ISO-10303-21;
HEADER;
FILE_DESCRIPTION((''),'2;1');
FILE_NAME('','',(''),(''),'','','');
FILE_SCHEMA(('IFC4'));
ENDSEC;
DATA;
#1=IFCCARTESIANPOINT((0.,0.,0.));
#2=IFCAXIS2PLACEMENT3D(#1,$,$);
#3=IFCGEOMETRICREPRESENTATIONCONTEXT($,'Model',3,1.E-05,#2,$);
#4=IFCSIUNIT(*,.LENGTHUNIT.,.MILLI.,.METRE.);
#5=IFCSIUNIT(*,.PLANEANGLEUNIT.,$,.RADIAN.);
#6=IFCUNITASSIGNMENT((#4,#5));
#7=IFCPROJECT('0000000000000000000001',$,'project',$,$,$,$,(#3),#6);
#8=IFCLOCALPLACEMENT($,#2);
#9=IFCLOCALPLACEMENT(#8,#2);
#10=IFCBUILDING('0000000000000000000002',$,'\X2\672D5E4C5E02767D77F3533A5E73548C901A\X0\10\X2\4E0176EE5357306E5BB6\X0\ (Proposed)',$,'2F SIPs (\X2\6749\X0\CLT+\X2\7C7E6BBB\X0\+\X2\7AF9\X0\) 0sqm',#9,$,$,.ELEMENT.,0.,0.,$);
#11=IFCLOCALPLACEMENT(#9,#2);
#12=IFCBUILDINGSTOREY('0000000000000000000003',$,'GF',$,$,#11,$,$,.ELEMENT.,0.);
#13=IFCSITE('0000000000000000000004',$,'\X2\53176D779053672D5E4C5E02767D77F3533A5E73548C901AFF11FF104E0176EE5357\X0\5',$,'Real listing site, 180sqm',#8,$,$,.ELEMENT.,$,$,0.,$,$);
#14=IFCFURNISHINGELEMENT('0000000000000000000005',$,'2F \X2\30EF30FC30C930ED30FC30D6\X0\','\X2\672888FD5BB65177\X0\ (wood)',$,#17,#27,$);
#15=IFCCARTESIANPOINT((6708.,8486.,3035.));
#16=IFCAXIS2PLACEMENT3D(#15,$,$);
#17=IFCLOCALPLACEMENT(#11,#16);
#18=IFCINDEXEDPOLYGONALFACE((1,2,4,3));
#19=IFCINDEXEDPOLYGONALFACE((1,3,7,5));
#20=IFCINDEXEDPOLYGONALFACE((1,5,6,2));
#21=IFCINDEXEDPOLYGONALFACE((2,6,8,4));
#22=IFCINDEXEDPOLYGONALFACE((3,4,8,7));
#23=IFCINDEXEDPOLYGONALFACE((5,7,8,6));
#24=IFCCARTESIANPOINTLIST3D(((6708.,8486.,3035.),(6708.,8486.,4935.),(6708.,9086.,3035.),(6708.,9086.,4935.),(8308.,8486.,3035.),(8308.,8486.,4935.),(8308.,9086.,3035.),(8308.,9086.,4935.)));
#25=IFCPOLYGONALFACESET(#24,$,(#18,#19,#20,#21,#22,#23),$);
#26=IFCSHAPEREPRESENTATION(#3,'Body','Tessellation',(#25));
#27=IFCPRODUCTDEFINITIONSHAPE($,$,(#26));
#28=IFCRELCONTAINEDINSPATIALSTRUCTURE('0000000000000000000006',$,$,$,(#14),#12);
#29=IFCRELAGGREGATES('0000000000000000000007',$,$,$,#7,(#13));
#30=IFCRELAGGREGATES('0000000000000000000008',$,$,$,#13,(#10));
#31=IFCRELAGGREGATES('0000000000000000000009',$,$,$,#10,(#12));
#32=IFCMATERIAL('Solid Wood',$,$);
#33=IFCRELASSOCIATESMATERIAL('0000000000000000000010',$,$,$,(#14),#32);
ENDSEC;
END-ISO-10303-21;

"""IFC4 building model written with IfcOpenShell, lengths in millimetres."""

from ifc_helpers import new_model, si_unit, frame, frame_2d, origin, place, context, project, spatial, rectangle, extrude, material, element, save


model = new_model("IFC4")

# Units and contexts
model_context = context("Model", 3, precision=1e-05, world=origin())
ifc_project = project(units=[si_unit("LENGTHUNIT", "METRE", prefix="MILLI"), si_unit("PLANEANGLEUNIT", "RADIAN")], contexts=[model_context])

# Site, building, storey
site_placement = place(None, origin())
site = spatial("IfcSite", under=ifc_project, at=site_placement, Name="北海道札幌市白石区平和通１０丁目南5", ObjectType="Real listing site, 180sqm", CompositionType="ELEMENT", RefElevation=0.0)
building_placement = place(site_placement, origin())
building = spatial("IfcBuilding", under=site, at=building_placement, Name="札幌市白石区平和通10丁目南の家 (Proposed)", ObjectType="2F SIPs (杉CLT+籾殻+竹) 0sqm", CompositionType="ELEMENT", ElevationOfRefHeight=0.0, ElevationOfTerrain=0.0)
storey_placement = place(building_placement, origin())
storey = spatial("IfcBuildingStorey", under=building, at=storey_placement, Name="GF", CompositionType="ELEMENT", Elevation=0.0)

# Shared definitions
ifc_material_1 = material(Name="Solid Wood")

# Furnishing element
furnishing_1_placement = place(storey_placement, frame((6708.0, 8486.0, 3035.0)))
element("IfcFurnishingElement", 1, at=furnishing_1_placement, inside=storey, material=ifc_material_1, Name="2F ワードローブ", Description="木製家具 (wood)", context=model_context, shape_type="SweptSolid", body=[
    extrude(rectangle(XDim=1600.0, YDim=600.0, at=frame_2d((800.0, 300.0))), frame((6708.0, 8486.0, 3035.0)), (0.0, 0.0, 1.0), 1900.0),
])

save(model, "model.ifc")
